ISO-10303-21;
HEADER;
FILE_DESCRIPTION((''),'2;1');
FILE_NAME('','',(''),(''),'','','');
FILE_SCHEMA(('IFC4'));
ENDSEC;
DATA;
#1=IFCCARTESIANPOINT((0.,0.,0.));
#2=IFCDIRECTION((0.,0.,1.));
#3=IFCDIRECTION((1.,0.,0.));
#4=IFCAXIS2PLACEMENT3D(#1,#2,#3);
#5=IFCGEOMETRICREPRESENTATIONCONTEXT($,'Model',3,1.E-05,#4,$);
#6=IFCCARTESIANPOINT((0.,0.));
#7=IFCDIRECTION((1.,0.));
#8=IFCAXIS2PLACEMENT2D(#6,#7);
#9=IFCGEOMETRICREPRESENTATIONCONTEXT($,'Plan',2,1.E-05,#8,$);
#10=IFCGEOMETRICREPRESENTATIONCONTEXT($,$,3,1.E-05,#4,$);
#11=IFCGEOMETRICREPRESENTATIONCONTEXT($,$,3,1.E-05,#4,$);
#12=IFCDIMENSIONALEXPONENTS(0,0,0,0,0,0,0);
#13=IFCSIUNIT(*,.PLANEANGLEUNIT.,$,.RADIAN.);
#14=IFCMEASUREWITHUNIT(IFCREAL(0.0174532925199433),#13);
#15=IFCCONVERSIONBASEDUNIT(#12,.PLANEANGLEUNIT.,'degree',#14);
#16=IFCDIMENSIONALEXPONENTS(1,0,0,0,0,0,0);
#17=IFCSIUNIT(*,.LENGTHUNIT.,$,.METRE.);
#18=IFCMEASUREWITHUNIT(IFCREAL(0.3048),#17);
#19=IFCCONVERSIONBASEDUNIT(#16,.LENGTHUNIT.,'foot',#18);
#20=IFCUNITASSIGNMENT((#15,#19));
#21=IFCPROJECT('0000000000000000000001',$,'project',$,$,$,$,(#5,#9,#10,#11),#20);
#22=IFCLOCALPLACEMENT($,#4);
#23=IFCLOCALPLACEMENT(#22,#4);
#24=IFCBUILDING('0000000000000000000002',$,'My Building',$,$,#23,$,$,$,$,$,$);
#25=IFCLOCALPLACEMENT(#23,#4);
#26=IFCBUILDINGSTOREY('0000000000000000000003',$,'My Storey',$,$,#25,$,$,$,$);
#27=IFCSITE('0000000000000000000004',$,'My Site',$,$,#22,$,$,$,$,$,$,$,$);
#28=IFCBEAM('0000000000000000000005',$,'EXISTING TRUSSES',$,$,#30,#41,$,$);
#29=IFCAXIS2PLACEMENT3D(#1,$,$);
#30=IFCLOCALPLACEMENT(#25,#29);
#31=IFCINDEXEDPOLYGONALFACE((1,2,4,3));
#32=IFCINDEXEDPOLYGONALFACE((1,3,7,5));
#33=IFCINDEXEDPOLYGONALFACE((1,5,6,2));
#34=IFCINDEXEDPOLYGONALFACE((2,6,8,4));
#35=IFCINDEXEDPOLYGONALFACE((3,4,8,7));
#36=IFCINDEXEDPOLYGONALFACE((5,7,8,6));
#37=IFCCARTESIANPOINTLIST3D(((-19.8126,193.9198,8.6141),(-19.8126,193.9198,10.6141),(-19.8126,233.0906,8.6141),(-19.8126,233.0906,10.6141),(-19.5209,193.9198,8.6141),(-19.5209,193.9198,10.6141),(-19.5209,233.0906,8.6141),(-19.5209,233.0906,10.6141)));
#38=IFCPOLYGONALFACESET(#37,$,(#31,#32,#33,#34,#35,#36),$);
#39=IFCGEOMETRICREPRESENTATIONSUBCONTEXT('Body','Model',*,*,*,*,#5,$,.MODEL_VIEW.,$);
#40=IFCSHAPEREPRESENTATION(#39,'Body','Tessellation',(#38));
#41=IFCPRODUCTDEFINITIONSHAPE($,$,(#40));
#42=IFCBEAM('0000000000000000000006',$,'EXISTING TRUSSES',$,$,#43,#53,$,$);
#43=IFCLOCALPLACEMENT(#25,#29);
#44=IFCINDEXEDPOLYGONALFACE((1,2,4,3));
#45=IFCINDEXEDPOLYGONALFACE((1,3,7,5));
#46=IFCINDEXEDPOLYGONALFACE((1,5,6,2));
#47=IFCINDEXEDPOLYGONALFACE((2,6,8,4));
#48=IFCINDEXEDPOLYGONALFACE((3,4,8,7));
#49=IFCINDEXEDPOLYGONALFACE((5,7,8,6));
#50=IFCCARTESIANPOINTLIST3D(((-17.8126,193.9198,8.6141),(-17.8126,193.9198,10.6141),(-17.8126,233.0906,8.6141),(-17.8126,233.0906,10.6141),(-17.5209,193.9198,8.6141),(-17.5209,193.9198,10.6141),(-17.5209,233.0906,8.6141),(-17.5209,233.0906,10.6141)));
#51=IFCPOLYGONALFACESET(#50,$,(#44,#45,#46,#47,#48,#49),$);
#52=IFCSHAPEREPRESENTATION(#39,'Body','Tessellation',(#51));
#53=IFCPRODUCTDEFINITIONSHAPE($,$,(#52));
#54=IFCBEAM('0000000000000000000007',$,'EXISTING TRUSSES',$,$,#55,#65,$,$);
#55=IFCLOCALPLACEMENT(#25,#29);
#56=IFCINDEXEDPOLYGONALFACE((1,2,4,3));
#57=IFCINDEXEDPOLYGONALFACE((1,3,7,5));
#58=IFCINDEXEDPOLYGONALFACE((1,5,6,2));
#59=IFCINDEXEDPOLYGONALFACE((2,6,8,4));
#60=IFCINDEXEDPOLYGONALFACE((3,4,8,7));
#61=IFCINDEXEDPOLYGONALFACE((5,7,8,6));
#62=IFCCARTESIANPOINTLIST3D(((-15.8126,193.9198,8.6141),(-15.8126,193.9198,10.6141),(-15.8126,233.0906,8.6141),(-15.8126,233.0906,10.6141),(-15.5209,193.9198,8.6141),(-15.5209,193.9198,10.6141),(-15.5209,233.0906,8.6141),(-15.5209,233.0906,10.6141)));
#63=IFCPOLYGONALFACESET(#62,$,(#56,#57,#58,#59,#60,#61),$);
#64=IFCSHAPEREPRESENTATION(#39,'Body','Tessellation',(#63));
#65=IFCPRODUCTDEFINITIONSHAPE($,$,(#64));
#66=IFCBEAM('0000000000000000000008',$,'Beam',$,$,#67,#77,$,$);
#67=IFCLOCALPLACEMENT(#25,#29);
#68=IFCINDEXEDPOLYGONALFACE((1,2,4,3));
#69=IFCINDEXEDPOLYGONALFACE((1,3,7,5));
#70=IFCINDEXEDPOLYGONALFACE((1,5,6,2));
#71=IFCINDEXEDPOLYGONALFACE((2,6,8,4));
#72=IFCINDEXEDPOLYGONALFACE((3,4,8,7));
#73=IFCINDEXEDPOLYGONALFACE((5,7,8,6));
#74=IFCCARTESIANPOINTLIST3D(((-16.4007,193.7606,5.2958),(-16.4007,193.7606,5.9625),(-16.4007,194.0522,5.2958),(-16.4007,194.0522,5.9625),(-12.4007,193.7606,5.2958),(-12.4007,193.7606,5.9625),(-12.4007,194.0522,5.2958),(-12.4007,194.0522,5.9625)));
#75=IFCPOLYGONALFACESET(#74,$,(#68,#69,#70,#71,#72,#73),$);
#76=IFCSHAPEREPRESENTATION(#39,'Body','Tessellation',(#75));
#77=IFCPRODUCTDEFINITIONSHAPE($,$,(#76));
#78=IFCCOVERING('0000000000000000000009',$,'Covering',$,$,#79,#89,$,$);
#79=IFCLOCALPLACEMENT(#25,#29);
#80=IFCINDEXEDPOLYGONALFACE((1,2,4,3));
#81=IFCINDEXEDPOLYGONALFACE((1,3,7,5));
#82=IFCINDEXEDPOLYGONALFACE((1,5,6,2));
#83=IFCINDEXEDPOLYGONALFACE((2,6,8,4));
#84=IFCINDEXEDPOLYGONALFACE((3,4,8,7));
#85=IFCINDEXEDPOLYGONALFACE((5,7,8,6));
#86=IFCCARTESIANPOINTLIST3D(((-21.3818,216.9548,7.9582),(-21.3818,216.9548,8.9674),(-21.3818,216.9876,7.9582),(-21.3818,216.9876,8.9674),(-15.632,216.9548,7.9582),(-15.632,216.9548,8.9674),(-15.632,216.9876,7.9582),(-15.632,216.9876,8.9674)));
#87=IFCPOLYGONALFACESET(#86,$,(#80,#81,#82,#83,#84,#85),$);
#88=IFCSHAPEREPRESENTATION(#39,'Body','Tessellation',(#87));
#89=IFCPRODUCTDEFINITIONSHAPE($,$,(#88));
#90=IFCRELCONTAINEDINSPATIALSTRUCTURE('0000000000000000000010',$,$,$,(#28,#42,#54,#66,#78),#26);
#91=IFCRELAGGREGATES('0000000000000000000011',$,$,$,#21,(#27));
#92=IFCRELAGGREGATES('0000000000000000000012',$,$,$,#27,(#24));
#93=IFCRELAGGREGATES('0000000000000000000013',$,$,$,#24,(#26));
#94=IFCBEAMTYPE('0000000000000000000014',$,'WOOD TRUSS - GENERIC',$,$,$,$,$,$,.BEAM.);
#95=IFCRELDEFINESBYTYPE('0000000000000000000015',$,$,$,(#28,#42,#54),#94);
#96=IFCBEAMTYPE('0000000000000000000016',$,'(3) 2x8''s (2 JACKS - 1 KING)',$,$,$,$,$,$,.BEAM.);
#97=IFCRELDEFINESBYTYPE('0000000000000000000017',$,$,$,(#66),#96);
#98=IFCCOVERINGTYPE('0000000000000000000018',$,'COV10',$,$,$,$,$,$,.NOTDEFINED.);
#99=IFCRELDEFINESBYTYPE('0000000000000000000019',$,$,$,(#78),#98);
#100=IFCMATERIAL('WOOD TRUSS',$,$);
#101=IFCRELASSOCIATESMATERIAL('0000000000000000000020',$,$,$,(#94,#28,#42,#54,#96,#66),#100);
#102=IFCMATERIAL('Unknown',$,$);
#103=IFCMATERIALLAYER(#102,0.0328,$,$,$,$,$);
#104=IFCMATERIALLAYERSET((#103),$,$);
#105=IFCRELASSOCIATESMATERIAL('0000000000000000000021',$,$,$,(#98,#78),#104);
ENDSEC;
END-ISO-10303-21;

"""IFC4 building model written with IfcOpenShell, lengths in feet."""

from ifc_helpers import new_model, entity, si_unit, converted_unit, frame, origin_with_axes, origin_2d_with_axis, place, context, subcontext, project, spatial, indexed_curve, rectangle, outline, extrude, material, layer, layer_set, layer_usage, material_profile, profile_set, profile_usage, type_object, element, save


model = new_model("IFC4")

# Units and contexts
model_context = context("Model", 3, precision=1e-05, world=origin_with_axes())
plan_context = context("Plan", 2, precision=1e-05, world=origin_2d_with_axis())
context_of_model_1 = context(None, 3, precision=1e-05, world=origin_with_axes())
context_of_model_2 = context(None, 3, precision=1e-05, world=origin_with_axes())
body_context = subcontext(model_context, "Body", "Model", "MODEL_VIEW")
ifc_project = project(units=[converted_unit("PLANEANGLEUNIT", "degree", entity("IfcReal", 0.0174532925199433), si_unit("PLANEANGLEUNIT", "RADIAN"), dimensions=[0, 0, 0, 0, 0, 0, 0]), converted_unit("LENGTHUNIT", "foot", entity("IfcReal", 0.3048), si_unit("LENGTHUNIT", "METRE"), dimensions=[1, 0, 0, 0, 0, 0, 0])], contexts=[model_context, plan_context, context_of_model_1, context_of_model_2])

# Site, building, storey
site_placement = place(None, origin_with_axes())
site = spatial("IfcSite", under=ifc_project, at=site_placement, Name="My Site")
building_placement = place(site_placement, origin_with_axes())
building = spatial("IfcBuilding", under=site, at=building_placement, Name="My Building")
storey_placement = place(building_placement, origin_with_axes())
storey = spatial("IfcBuildingStorey", under=building, at=storey_placement, Name="My Storey")

# Beams
ifc_material_1 = material(Name="WOOD TRUSS")
ifc_material_profile_1 = material_profile(ifc_material_1, rectangle(XDim=0.2917, YDim=2.0))
ifc_profile_set_1 = profile_set([ifc_material_profile_1])
ifc_profile_usage_1 = profile_usage(ifc_profile_set_1, cardinal=5)
beam_type_1 = type_object("IfcBeamType", Name="WOOD TRUSS - GENERIC", PredefinedType="BEAM", material=ifc_profile_set_1)
beam_1_placement = place(storey_placement, frame((-19.6667, 193.9198, 9.6141), z_axis=(0.0, 1.0, 0.0), x_axis=(-1.0, 0.0, 0.0)))
element("IfcBeam", 1, at=beam_1_placement, inside=storey, type_object=beam_type_1, material=ifc_profile_usage_1, Name="EXISTING TRUSSES", context=body_context, shape_type="SweptSolid", body=[
    extrude(rectangle(XDim=0.2917, YDim=2.0), origin_with_axes(), (0.0, 0.0, 1.0), 39.1707),
])
ifc_profile_usage_2 = profile_usage(ifc_profile_set_1, cardinal=5)
beam_2_placement = place(storey_placement, frame((-17.6667, 193.9198, 9.6141), z_axis=(0.0, 1.0, 0.0), x_axis=(-1.0, 0.0, 0.0)))
element("IfcBeam", 2, at=beam_2_placement, inside=storey, type_object=beam_type_1, material=ifc_profile_usage_2, Name="EXISTING TRUSSES", context=body_context, shape_type="SweptSolid", body=[
    extrude(rectangle(XDim=0.2917, YDim=2.0), origin_with_axes(), (0.0, 0.0, 1.0), 39.1707),
])
ifc_profile_usage_3 = profile_usage(ifc_profile_set_1, cardinal=5)
beam_3_placement = place(storey_placement, frame((-15.6667, 193.9198, 9.6141), z_axis=(0.0, 1.0, 0.0), x_axis=(-1.0, 0.0, 0.0)))
element("IfcBeam", 3, at=beam_3_placement, inside=storey, type_object=beam_type_1, material=ifc_profile_usage_3, Name="EXISTING TRUSSES", context=body_context, shape_type="SweptSolid", body=[
    extrude(rectangle(XDim=0.2917, YDim=2.0), origin_with_axes(), (0.0, 0.0, 1.0), 39.1707),
])
ifc_material_profile_2 = material_profile(ifc_material_1, rectangle(XDim=0.2917, YDim=0.6667))
ifc_profile_set_2 = profile_set([ifc_material_profile_2])
ifc_profile_usage_4 = profile_usage(ifc_profile_set_2, cardinal=5)
beam_type_2 = type_object("IfcBeamType", Name="(3) 2x8's (2 JACKS - 1 KING)", PredefinedType="BEAM", material=ifc_profile_set_2)
beam_4_placement = place(storey_placement, frame((-16.4007, 193.9064, 5.6292), z_axis=(1.0, 0.0, 0.0), x_axis=(0.0, 1.0, 0.0)))
element("IfcBeam", 4, at=beam_4_placement, inside=storey, type_object=beam_type_2, material=ifc_profile_usage_4, Name="Beam", context=body_context, shape_type="SweptSolid", body=[
    extrude(rectangle(XDim=0.2917, YDim=0.6667), origin_with_axes(), (0.0, 0.0, 1.0), 4.0),
])

# Covering
ifc_material_2 = material(Name="Unknown")
ifc_layer_1 = layer(ifc_material_2, 0.0328)
ifc_layer_set_1 = layer_set([ifc_layer_1])
ifc_layer_usage_1 = layer_usage(ifc_layer_set_1, "AXIS2", "POSITIVE", 0.0)
covering_type_1 = type_object("IfcCoveringType", Name="COV10", PredefinedType="NOTDEFINED", material=ifc_layer_set_1)
covering_1_placement = place(storey_placement, frame((-21.3818, 216.9548, 7.9582), z_axis=(0.0, 0.0, 1.0), x_axis=(1.0, 0.0, 0.0)))
element("IfcCovering", 5, at=covering_1_placement, inside=storey, type_object=covering_type_1, material=ifc_layer_usage_1, Name="Covering", context=body_context, shape_type="SweptSolid", body=[
    extrude(outline(indexed_curve([(0.0, 0.0), (0.0, 0.0328), (5.7498, 0.0328), (5.7498, 0.0), (0.0, 0.0)], self_intersect=False)), origin_with_axes(), (0.0, 0.0, 1.0), 1.0092),
])

save(model, "model.ifc")
